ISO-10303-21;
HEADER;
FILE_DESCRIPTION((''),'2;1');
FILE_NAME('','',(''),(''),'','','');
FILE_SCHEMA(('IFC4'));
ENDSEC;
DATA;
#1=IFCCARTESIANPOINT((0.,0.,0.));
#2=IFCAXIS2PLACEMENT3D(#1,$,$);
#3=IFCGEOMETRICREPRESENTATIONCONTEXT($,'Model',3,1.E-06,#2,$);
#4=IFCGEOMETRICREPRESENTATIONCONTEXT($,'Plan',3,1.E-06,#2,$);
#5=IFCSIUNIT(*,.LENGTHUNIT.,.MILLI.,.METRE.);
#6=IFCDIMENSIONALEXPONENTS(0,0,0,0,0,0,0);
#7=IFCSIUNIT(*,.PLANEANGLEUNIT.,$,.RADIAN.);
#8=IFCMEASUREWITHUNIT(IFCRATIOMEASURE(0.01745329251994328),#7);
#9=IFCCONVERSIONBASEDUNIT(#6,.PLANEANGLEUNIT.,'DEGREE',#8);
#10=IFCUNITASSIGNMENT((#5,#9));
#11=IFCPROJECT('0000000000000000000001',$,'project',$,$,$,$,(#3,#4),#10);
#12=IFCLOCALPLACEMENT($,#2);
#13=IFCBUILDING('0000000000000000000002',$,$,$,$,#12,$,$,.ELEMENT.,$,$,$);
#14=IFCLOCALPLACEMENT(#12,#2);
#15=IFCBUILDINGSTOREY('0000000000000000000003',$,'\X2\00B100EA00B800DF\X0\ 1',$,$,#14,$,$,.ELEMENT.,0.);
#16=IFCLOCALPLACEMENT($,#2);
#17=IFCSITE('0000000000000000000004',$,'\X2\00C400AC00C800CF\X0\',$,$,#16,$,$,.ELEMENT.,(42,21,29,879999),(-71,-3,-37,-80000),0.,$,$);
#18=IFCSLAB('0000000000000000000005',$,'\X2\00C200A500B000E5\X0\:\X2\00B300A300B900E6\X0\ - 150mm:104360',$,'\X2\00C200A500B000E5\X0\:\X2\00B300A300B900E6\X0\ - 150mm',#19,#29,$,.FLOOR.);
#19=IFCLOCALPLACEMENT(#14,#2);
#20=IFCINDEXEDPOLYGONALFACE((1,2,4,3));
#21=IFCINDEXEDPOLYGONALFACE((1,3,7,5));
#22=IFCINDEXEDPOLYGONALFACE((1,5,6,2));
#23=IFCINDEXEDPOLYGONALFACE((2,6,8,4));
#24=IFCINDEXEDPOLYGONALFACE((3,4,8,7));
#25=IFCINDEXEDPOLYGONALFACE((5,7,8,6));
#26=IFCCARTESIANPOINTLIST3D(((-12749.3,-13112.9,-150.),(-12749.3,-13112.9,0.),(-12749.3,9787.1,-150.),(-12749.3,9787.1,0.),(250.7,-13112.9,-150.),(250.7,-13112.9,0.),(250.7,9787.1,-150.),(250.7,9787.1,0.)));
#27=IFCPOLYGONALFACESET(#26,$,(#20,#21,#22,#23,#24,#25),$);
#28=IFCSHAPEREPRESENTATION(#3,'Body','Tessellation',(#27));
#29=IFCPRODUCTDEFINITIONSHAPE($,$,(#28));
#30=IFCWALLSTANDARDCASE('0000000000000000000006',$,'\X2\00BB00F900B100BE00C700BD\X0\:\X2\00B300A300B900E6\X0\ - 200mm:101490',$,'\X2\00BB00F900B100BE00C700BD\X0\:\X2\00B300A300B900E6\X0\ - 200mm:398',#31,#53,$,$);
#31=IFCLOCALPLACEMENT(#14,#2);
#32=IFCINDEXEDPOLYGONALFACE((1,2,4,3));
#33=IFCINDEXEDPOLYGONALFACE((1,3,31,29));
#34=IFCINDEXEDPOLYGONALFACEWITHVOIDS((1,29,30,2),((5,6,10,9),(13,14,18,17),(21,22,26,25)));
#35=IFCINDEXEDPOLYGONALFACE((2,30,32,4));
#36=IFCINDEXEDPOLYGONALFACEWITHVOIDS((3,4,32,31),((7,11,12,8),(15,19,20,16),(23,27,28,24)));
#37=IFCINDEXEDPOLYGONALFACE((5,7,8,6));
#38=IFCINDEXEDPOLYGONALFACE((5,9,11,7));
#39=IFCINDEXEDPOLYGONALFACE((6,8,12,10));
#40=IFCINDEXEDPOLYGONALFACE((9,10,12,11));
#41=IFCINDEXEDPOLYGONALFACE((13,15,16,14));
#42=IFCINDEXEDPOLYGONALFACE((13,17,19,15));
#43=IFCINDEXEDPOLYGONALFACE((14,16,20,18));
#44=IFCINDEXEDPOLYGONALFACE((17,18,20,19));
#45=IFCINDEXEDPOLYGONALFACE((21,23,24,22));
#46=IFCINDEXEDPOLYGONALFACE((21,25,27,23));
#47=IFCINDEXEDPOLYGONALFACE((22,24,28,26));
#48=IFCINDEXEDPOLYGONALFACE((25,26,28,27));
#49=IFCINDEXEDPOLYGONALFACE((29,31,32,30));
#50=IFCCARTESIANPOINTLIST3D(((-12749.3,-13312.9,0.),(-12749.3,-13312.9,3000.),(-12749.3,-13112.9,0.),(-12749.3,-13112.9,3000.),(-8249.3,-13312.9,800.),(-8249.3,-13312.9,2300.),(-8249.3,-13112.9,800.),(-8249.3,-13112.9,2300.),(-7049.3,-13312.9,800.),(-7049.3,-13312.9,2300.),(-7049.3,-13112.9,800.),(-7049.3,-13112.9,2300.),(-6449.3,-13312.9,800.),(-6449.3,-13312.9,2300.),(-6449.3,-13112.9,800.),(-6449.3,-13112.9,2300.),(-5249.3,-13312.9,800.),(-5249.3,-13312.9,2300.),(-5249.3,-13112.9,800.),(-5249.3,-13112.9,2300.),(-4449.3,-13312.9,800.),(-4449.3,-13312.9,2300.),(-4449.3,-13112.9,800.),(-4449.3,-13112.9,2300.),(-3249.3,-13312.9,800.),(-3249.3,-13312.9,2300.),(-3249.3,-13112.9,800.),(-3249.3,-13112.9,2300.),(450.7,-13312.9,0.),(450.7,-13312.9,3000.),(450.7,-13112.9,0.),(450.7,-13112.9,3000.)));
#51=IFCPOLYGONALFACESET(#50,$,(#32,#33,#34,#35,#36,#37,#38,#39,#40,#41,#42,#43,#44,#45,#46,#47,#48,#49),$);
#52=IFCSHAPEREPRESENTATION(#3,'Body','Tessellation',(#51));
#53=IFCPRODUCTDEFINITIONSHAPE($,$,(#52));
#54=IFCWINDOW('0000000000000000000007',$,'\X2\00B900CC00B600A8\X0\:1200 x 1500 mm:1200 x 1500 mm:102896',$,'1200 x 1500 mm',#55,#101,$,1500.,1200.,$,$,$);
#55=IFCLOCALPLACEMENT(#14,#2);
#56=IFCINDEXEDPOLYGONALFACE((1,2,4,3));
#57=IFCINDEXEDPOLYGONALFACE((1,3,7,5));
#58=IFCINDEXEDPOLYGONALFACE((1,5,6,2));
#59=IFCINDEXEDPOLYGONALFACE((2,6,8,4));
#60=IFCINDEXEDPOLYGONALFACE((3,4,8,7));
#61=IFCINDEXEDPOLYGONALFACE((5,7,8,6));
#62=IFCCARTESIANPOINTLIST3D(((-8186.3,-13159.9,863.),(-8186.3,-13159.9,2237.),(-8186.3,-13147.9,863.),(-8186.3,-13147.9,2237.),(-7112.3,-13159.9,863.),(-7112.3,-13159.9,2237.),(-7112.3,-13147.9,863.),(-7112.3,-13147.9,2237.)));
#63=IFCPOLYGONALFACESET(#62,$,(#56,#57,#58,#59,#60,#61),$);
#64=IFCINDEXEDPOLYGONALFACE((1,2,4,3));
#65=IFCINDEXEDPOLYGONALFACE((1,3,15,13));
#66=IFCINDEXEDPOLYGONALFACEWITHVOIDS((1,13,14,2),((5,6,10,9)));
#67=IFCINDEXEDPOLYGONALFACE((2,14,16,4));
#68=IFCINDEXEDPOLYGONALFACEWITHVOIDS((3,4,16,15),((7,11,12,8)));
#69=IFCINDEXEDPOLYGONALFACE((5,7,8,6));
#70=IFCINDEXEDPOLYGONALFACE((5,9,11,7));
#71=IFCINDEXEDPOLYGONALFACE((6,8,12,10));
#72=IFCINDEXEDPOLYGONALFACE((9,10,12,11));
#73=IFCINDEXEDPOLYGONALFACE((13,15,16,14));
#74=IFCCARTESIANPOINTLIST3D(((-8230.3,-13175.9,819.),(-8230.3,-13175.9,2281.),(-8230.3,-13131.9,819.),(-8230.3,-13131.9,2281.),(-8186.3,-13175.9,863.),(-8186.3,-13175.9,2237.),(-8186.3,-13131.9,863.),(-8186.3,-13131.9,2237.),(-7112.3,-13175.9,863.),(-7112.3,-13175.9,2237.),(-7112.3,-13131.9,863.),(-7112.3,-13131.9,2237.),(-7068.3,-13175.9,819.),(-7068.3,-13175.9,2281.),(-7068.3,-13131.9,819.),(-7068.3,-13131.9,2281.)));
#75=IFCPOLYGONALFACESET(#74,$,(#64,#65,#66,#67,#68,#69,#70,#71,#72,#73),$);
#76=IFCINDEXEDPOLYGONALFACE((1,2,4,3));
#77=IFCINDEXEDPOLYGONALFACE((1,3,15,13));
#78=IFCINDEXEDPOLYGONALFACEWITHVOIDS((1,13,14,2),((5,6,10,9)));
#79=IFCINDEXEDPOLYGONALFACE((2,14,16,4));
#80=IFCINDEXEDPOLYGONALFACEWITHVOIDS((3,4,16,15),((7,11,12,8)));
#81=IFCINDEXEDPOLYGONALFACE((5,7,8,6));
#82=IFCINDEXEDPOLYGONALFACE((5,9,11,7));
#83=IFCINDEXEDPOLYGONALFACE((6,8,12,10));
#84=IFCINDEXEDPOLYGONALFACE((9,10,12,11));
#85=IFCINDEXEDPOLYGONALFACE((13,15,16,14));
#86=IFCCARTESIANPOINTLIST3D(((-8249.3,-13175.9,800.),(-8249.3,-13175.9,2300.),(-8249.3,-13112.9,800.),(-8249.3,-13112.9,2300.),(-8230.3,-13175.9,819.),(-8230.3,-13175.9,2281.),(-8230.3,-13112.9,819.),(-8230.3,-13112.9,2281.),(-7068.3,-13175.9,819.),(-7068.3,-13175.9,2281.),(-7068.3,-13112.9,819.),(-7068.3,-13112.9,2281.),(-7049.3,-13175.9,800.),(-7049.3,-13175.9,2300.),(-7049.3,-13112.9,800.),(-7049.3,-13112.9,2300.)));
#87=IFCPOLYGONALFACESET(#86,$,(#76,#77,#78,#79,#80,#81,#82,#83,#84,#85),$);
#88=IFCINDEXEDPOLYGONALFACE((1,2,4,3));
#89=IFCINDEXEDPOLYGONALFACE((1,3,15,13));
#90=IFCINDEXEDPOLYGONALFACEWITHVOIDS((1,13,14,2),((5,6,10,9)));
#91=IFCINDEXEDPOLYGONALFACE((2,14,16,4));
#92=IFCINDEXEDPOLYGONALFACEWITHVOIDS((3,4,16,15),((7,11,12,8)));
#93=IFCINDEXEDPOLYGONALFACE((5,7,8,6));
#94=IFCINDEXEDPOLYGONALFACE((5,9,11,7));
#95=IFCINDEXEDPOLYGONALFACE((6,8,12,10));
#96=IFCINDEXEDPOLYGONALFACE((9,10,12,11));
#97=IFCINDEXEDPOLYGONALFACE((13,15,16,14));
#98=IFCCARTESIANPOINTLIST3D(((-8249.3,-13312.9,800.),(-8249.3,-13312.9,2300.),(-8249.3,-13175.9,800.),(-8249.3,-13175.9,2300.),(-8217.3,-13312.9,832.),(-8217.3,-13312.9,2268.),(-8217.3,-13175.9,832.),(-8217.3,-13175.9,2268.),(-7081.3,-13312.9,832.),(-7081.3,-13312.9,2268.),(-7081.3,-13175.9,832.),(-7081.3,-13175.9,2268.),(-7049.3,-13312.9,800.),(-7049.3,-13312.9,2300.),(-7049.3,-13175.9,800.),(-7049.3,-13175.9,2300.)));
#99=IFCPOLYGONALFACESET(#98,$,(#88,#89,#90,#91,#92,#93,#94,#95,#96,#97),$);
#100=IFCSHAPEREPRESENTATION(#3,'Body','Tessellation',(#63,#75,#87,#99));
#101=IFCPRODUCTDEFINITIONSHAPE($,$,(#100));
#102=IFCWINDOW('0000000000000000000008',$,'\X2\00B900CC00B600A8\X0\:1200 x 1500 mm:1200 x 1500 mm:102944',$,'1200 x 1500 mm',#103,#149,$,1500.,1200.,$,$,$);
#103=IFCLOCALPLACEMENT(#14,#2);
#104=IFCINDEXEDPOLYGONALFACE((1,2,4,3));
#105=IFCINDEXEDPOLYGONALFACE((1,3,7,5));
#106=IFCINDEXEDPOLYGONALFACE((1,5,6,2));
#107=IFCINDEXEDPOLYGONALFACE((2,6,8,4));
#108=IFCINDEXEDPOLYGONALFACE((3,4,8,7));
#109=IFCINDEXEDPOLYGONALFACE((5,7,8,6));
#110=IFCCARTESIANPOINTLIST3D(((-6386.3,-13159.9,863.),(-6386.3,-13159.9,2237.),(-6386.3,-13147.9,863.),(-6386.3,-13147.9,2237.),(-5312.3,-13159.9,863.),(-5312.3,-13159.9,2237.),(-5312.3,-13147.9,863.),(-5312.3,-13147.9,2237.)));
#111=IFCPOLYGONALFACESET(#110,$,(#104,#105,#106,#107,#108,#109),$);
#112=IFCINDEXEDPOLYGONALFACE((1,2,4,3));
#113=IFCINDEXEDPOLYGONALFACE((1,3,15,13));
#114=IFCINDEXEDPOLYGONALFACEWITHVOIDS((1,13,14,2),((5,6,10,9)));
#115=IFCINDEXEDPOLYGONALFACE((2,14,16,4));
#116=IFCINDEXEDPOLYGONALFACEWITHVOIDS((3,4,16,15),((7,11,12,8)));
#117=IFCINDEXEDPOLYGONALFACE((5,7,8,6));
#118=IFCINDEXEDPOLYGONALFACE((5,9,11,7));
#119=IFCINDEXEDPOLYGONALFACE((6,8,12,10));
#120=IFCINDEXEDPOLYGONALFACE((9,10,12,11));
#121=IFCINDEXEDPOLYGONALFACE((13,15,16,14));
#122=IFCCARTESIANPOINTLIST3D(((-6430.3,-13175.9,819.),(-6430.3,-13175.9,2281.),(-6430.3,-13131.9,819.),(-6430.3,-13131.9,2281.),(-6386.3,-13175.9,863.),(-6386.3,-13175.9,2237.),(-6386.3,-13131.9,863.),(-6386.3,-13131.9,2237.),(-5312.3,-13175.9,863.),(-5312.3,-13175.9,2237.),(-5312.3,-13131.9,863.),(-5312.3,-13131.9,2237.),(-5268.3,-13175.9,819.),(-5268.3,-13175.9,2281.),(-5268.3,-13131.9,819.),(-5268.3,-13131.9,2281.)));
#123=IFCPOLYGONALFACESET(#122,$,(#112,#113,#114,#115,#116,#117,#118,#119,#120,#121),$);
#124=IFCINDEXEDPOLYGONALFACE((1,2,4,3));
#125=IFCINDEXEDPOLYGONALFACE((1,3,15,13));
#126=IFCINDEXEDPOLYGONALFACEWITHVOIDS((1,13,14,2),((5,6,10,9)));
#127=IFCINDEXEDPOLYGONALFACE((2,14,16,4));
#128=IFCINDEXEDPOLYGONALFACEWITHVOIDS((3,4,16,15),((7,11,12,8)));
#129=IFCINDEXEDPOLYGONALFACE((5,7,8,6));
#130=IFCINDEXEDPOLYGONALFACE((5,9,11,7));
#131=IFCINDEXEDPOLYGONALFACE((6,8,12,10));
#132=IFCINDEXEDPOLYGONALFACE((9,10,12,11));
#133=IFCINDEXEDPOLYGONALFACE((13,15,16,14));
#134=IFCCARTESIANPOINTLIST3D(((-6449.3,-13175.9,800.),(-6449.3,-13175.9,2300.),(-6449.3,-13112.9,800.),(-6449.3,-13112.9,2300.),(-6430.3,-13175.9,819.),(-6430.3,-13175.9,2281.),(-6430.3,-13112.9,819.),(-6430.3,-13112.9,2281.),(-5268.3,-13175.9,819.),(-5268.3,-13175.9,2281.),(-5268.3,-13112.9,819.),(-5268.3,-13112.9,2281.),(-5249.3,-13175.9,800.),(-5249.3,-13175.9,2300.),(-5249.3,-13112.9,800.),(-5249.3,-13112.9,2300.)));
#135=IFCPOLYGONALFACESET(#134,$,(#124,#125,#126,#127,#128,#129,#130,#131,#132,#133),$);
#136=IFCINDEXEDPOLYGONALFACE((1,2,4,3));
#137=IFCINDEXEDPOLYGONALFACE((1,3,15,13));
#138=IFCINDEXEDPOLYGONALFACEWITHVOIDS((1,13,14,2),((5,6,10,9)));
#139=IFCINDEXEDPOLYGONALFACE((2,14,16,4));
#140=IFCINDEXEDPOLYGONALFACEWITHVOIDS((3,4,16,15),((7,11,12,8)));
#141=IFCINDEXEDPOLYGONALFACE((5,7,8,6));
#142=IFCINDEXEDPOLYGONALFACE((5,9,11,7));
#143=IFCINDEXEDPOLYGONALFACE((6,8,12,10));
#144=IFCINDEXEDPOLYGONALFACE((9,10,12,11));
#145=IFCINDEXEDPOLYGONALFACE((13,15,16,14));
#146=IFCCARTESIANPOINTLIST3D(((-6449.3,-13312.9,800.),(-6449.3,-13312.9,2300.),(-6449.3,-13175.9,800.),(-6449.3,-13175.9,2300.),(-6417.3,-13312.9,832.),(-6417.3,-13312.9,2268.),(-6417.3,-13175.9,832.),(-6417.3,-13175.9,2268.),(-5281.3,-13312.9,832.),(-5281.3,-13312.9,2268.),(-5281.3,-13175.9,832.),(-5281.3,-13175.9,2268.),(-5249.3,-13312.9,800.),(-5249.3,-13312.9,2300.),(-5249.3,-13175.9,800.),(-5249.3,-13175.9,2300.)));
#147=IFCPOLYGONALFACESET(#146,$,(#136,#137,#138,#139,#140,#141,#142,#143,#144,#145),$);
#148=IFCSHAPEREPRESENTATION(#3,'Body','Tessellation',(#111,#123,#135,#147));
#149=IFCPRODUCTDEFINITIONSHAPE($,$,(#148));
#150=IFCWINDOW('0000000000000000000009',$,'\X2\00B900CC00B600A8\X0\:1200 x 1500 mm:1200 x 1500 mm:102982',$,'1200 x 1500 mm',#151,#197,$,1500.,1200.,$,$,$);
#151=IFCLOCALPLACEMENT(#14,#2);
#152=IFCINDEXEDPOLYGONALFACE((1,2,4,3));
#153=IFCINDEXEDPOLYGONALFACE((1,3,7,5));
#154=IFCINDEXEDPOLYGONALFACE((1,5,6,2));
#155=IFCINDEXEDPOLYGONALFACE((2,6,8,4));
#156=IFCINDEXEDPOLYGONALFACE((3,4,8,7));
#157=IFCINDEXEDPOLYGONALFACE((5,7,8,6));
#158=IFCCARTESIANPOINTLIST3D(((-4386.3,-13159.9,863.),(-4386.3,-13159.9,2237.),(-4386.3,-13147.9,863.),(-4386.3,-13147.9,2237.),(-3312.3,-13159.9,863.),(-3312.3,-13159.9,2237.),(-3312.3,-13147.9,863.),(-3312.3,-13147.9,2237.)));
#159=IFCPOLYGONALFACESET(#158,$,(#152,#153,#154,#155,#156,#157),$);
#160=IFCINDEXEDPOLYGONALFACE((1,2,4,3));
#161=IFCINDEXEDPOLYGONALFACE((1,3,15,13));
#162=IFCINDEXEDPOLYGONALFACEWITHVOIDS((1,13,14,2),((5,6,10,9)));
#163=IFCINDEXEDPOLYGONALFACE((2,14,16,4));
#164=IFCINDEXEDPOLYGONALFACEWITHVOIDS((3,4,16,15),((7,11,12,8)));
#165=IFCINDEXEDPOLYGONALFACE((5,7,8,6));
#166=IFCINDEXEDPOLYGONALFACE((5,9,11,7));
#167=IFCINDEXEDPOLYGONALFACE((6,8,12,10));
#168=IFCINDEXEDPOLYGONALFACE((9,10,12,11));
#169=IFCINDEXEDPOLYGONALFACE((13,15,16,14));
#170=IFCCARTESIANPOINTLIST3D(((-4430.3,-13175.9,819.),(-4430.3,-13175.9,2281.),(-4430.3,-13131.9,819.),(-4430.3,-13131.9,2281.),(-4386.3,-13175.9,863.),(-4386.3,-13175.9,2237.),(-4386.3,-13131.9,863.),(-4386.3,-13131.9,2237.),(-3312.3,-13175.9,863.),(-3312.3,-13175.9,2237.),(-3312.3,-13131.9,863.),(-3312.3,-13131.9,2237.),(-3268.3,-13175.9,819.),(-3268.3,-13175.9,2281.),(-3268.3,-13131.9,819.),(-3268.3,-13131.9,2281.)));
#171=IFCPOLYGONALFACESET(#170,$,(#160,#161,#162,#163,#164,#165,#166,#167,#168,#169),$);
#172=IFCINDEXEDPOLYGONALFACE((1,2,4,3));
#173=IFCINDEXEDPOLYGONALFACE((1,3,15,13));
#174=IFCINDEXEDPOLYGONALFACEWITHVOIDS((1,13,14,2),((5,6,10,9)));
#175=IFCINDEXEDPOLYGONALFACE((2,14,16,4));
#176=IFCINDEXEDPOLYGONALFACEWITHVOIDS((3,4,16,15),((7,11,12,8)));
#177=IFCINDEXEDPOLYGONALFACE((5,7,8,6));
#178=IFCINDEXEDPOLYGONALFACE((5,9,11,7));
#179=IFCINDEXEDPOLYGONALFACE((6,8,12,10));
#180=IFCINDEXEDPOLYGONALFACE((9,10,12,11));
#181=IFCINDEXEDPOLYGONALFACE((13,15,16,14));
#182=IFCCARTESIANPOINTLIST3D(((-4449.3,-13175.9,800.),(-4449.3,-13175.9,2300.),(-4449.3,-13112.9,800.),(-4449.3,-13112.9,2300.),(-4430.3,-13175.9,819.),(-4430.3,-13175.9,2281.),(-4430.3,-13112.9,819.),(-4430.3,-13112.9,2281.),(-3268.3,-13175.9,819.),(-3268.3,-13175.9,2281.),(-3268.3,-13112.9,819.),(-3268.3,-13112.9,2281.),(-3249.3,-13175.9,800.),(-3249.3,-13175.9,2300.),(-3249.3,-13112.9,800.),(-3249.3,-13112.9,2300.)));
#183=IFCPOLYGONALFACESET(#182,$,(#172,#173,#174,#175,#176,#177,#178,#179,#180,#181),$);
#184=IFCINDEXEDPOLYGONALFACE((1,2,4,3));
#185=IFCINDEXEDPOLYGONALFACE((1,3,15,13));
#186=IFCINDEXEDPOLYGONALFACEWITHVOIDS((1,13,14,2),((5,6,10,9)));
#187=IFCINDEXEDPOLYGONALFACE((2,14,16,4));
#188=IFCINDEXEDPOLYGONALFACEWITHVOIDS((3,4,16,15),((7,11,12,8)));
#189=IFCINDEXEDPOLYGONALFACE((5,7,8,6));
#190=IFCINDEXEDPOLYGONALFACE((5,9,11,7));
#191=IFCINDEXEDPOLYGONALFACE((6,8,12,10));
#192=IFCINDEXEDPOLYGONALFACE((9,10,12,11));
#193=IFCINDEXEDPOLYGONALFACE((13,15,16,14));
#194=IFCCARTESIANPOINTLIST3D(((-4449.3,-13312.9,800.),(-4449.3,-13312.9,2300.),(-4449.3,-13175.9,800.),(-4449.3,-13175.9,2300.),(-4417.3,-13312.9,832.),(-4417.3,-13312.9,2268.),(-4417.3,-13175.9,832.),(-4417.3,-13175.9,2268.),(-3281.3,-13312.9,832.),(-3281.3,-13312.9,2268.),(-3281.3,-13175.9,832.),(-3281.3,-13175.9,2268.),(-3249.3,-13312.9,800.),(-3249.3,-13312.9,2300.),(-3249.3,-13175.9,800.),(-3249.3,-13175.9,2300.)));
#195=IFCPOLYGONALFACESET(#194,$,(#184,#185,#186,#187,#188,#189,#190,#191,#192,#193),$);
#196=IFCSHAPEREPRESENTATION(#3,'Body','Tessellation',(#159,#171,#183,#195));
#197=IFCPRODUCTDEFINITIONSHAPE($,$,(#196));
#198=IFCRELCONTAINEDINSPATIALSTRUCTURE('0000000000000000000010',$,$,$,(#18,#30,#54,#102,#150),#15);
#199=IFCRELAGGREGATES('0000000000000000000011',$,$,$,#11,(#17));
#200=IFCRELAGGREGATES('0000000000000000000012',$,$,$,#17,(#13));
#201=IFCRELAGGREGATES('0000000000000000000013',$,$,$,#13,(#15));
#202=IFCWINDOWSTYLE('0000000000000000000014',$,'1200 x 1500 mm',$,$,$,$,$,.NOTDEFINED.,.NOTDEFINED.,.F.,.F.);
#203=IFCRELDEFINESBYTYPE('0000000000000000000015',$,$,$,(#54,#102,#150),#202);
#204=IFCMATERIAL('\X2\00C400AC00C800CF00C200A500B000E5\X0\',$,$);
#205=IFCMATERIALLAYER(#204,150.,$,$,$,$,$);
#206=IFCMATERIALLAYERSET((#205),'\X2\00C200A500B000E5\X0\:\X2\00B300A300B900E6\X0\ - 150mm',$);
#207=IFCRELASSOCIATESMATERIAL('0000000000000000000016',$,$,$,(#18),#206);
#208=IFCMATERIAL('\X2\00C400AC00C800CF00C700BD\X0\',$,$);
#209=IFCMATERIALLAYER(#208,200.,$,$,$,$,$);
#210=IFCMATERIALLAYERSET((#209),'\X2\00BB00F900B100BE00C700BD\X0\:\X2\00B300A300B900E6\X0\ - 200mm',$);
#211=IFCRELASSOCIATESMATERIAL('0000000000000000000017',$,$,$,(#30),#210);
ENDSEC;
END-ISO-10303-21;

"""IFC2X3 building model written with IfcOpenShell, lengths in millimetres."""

from ifc_helpers import new_model, entity, si_unit, converted_unit, frame, frame_2d, origin, origin_2d_with_axis, place, context, project, spatial, polyline, rectangle, outline, extrude, source, transform, mapped, material, layer, layer_set, layer_usage, type_object, type_shapes, element, fill, save


model = new_model("IFC2X3")

# Units and contexts
model_context = context("Model", 3, precision=1e-06, world=origin())
plan_context = context("Plan", 3, precision=1e-06, world=origin())
ifc_project = project(units=[si_unit("LENGTHUNIT", "METRE", prefix="MILLI"), converted_unit("PLANEANGLEUNIT", "DEGREE", entity("IfcRatioMeasure", 0.01745329251994328), si_unit("PLANEANGLEUNIT", "RADIAN"), dimensions=[0, 0, 0, 0, 0, 0, 0])], contexts=[model_context, plan_context])

# Site, building, storey
site_placement = place(None, origin())
site = spatial("IfcSite", under=ifc_project, at=site_placement, Name="Ä¬ÈÏ", CompositionType="ELEMENT", RefLatitude=(42, 21, 29, 879999), RefLongitude=(-71, -3, -37, -80000), RefElevation=0.0)
building_placement = place(None, origin())
building = spatial("IfcBuilding", under=site, at=building_placement, CompositionType="ELEMENT")
storey_placement = place(building_placement, origin())
storey = spatial("IfcBuildingStorey", under=building, at=storey_placement, Name="±ê¸ß 1", CompositionType="ELEMENT", Elevation=0.0)

# Slab
ifc_material_1 = material(Name="Ä¬ÈÏÂ¥°å")
ifc_layer_1 = layer(ifc_material_1, 150.0)
ifc_layer_set_1 = layer_set([ifc_layer_1], Name="Â¥°å:³£¹æ - 150mm")
ifc_layer_usage_1 = layer_usage(ifc_layer_set_1, "AXIS3", "POSITIVE", 0.0)
slab_placement = place(storey_placement, frame((-12749.3, -13112.9, -150.0)))
element("IfcSlab", 1, at=slab_placement, inside=storey, material=ifc_layer_usage_1, Name="Â¥°å:³£¹æ - 150mm:104360", ObjectType="Â¥°å:³£¹æ - 150mm", PredefinedType="FLOOR", context=model_context, shape_type="SweptSolid", body=[
    extrude(rectangle(XDim=13000.0, YDim=22900.0, at=frame_2d((0.0, 0.0), x_axis=(-1.0, 0.0))), frame((6500.0, 11450.0, 150.0), z_axis=(0.0, 0.0, -1.0), x_axis=(-1.0, 0.0, 0.0)), (0.0, 0.0, 1.0), 150.0),
])

# Wall, openings, windows
ifc_material_2 = material(Name="Ä¬ÈÏÇ½")
ifc_layer_2 = layer(ifc_material_2, 200.0)
ifc_layer_set_2 = layer_set([ifc_layer_2], Name="»ù±¾Ç½:³£¹æ - 200mm")
ifc_layer_usage_2 = layer_usage(ifc_layer_set_2, "AXIS2", "NEGATIVE", 100.0)
wall_1_placement = place(storey_placement, frame((-12749.3, -13212.9, 0.0)))
wall_1 = element("IfcWallStandardCase", 2, at=wall_1_placement, inside=storey, material=ifc_layer_usage_2, Name="»ù±¾Ç½:³£¹æ - 200mm:101490", ObjectType="»ù±¾Ç½:³£¹æ - 200mm:398", context=model_context, shape_type="SweptSolid", body=[
    extrude(rectangle(XDim=13200.0, YDim=200.0, at=frame_2d((6600.0, 0.0), x_axis=(-1.0, 0.0))), origin(), (0.0, 0.0, 1.0), 3000.0),
])
opening_1_placement = place(wall_1_placement, frame((4500.0, -100.0, 800.0)))
opening_1 = element("IfcOpeningElement", 3, at=opening_1_placement, cuts=wall_1, ObjectType="Opening", context=model_context, shape_type="SweptSolid", body=[
    extrude(rectangle(XDim=1500.0, YDim=1200.0, at=frame_2d((750.0, 600.0), x_axis=(1.0, 0.0))), frame((0.0, 0.0, 0.0), z_axis=(0.0, 1.0, 0.0), x_axis=(0.0, 0.0, 1.0)), (0.0, 0.0, 1.0), 200.0),
])
opening_2_placement = place(wall_1_placement, frame((6300.0, -100.0, 800.0)))
opening_2 = element("IfcOpeningElement", 4, at=opening_2_placement, cuts=wall_1, ObjectType="Opening", context=model_context, shape_type="SweptSolid", body=[
    extrude(rectangle(XDim=1500.0, YDim=1200.0, at=frame_2d((750.0, 600.0), x_axis=(1.0, 0.0))), frame((0.0, 0.0, 0.0), z_axis=(0.0, 1.0, 0.0), x_axis=(0.0, 0.0, 1.0)), (0.0, 0.0, 1.0), 200.0),
])
opening_3_placement = place(wall_1_placement, frame((8300.0, -100.0, 800.0)))
opening_3 = element("IfcOpeningElement", 5, at=opening_3_placement, cuts=wall_1, ObjectType="Opening", context=model_context, shape_type="SweptSolid", body=[
    extrude(rectangle(XDim=1500.0, YDim=1200.0, at=frame_2d((750.0, 600.0), x_axis=(1.0, 0.0))), frame((0.0, 0.0, 0.0), z_axis=(0.0, 1.0, 0.0), x_axis=(0.0, 0.0, 1.0)), (0.0, 0.0, 1.0), 200.0),
])
window_style = type_object("IfcWindowStyle", Name="1200 x 1500 mm", ConstructionType="NOTDEFINED", OperationType="NOTDEFINED", ParameterTakesPrecedence=False, Sizeable=False)
shared_shape = source(origin(), model_context, "Body", "SweptSolid", [
    extrude(rectangle(XDim=12.0, YDim=1074.0, at=origin_2d_with_axis()), frame((600.0, 159.0, 63.0), z_axis=(0.0, 0.0, 1.0), x_axis=(0.0, -1.0, 0.0)), (0.0, 0.0, 1.0), 1374.0),
    extrude(outline(polyline([(-581.0, -731.0), (581.0, -731.0), (581.0, 731.0), (-581.0, 731.0), (-581.0, -731.0)]), holes=[polyline([(-537.0, -687.0), (-537.0, 687.0), (537.0, 687.0), (537.0, -687.0), (-537.0, -687.0)])]), frame((600.0, 137.0, 750.0), z_axis=(0.0, 1.0, 0.0), x_axis=(1.0, 0.0, 0.0)), (0.0, 0.0, 1.0), 44.0),
    extrude(outline(polyline([(-600.0, -750.0), (600.0, -750.0), (600.0, 750.0), (-600.0, 750.0), (-600.0, -750.0)]), holes=[polyline([(-581.0, -731.0), (-581.0, 731.0), (581.0, 731.0), (581.0, -731.0), (-581.0, -731.0)])]), frame((600.0, 137.0, 750.0), z_axis=(0.0, 1.0, 0.0), x_axis=(1.0, 0.0, 0.0)), (0.0, 0.0, 1.0), 63.0),
    extrude(outline(polyline([(-600.0, -750.0), (600.0, -750.0), (600.0, 750.0), (-600.0, 750.0), (-600.0, -750.0)]), holes=[polyline([(-568.0, -718.0), (-568.0, 718.0), (568.0, 718.0), (568.0, -718.0), (-568.0, -718.0)])]), frame((600.0, 0.0, 750.0), z_axis=(0.0, 1.0, 0.0), x_axis=(1.0, 0.0, 0.0)), (0.0, 0.0, 1.0), 137.0),
])
type_shapes(window_style, [shared_shape])
window_1_placement = place(opening_1_placement, origin())
window_1 = element("IfcWindow", 6, at=window_1_placement, inside=storey, type_object=window_style, Name="¹Ì¶¨:1200 x 1500 mm:1200 x 1500 mm:102896", ObjectType="1200 x 1500 mm", OverallHeight=1500.0, OverallWidth=1200.0, context=model_context, shape_type="MappedRepresentation", body=[
    mapped(shared_shape, transform((0.0, 0.0, 0.0), scale=1.0)),
])
fill(opening_1, window_1)
window_2_placement = place(opening_2_placement, origin())
window_2 = element("IfcWindow", 7, at=window_2_placement, inside=storey, type_object=window_style, Name="¹Ì¶¨:1200 x 1500 mm:1200 x 1500 mm:102944", ObjectType="1200 x 1500 mm", OverallHeight=1500.0, OverallWidth=1200.0, context=model_context, shape_type="MappedRepresentation", body=[
    mapped(shared_shape, transform((0.0, 0.0, 0.0), scale=1.0)),
])
fill(opening_2, window_2)
window_3_placement = place(opening_3_placement, origin())
window_3 = element("IfcWindow", 8, at=window_3_placement, inside=storey, type_object=window_style, Name="¹Ì¶¨:1200 x 1500 mm:1200 x 1500 mm:102982", ObjectType="1200 x 1500 mm", OverallHeight=1500.0, OverallWidth=1200.0, context=model_context, shape_type="MappedRepresentation", body=[
    mapped(shared_shape, transform((0.0, 0.0, 0.0), scale=1.0)),
])
fill(opening_3, window_3)

save(model, "model.ifc")
